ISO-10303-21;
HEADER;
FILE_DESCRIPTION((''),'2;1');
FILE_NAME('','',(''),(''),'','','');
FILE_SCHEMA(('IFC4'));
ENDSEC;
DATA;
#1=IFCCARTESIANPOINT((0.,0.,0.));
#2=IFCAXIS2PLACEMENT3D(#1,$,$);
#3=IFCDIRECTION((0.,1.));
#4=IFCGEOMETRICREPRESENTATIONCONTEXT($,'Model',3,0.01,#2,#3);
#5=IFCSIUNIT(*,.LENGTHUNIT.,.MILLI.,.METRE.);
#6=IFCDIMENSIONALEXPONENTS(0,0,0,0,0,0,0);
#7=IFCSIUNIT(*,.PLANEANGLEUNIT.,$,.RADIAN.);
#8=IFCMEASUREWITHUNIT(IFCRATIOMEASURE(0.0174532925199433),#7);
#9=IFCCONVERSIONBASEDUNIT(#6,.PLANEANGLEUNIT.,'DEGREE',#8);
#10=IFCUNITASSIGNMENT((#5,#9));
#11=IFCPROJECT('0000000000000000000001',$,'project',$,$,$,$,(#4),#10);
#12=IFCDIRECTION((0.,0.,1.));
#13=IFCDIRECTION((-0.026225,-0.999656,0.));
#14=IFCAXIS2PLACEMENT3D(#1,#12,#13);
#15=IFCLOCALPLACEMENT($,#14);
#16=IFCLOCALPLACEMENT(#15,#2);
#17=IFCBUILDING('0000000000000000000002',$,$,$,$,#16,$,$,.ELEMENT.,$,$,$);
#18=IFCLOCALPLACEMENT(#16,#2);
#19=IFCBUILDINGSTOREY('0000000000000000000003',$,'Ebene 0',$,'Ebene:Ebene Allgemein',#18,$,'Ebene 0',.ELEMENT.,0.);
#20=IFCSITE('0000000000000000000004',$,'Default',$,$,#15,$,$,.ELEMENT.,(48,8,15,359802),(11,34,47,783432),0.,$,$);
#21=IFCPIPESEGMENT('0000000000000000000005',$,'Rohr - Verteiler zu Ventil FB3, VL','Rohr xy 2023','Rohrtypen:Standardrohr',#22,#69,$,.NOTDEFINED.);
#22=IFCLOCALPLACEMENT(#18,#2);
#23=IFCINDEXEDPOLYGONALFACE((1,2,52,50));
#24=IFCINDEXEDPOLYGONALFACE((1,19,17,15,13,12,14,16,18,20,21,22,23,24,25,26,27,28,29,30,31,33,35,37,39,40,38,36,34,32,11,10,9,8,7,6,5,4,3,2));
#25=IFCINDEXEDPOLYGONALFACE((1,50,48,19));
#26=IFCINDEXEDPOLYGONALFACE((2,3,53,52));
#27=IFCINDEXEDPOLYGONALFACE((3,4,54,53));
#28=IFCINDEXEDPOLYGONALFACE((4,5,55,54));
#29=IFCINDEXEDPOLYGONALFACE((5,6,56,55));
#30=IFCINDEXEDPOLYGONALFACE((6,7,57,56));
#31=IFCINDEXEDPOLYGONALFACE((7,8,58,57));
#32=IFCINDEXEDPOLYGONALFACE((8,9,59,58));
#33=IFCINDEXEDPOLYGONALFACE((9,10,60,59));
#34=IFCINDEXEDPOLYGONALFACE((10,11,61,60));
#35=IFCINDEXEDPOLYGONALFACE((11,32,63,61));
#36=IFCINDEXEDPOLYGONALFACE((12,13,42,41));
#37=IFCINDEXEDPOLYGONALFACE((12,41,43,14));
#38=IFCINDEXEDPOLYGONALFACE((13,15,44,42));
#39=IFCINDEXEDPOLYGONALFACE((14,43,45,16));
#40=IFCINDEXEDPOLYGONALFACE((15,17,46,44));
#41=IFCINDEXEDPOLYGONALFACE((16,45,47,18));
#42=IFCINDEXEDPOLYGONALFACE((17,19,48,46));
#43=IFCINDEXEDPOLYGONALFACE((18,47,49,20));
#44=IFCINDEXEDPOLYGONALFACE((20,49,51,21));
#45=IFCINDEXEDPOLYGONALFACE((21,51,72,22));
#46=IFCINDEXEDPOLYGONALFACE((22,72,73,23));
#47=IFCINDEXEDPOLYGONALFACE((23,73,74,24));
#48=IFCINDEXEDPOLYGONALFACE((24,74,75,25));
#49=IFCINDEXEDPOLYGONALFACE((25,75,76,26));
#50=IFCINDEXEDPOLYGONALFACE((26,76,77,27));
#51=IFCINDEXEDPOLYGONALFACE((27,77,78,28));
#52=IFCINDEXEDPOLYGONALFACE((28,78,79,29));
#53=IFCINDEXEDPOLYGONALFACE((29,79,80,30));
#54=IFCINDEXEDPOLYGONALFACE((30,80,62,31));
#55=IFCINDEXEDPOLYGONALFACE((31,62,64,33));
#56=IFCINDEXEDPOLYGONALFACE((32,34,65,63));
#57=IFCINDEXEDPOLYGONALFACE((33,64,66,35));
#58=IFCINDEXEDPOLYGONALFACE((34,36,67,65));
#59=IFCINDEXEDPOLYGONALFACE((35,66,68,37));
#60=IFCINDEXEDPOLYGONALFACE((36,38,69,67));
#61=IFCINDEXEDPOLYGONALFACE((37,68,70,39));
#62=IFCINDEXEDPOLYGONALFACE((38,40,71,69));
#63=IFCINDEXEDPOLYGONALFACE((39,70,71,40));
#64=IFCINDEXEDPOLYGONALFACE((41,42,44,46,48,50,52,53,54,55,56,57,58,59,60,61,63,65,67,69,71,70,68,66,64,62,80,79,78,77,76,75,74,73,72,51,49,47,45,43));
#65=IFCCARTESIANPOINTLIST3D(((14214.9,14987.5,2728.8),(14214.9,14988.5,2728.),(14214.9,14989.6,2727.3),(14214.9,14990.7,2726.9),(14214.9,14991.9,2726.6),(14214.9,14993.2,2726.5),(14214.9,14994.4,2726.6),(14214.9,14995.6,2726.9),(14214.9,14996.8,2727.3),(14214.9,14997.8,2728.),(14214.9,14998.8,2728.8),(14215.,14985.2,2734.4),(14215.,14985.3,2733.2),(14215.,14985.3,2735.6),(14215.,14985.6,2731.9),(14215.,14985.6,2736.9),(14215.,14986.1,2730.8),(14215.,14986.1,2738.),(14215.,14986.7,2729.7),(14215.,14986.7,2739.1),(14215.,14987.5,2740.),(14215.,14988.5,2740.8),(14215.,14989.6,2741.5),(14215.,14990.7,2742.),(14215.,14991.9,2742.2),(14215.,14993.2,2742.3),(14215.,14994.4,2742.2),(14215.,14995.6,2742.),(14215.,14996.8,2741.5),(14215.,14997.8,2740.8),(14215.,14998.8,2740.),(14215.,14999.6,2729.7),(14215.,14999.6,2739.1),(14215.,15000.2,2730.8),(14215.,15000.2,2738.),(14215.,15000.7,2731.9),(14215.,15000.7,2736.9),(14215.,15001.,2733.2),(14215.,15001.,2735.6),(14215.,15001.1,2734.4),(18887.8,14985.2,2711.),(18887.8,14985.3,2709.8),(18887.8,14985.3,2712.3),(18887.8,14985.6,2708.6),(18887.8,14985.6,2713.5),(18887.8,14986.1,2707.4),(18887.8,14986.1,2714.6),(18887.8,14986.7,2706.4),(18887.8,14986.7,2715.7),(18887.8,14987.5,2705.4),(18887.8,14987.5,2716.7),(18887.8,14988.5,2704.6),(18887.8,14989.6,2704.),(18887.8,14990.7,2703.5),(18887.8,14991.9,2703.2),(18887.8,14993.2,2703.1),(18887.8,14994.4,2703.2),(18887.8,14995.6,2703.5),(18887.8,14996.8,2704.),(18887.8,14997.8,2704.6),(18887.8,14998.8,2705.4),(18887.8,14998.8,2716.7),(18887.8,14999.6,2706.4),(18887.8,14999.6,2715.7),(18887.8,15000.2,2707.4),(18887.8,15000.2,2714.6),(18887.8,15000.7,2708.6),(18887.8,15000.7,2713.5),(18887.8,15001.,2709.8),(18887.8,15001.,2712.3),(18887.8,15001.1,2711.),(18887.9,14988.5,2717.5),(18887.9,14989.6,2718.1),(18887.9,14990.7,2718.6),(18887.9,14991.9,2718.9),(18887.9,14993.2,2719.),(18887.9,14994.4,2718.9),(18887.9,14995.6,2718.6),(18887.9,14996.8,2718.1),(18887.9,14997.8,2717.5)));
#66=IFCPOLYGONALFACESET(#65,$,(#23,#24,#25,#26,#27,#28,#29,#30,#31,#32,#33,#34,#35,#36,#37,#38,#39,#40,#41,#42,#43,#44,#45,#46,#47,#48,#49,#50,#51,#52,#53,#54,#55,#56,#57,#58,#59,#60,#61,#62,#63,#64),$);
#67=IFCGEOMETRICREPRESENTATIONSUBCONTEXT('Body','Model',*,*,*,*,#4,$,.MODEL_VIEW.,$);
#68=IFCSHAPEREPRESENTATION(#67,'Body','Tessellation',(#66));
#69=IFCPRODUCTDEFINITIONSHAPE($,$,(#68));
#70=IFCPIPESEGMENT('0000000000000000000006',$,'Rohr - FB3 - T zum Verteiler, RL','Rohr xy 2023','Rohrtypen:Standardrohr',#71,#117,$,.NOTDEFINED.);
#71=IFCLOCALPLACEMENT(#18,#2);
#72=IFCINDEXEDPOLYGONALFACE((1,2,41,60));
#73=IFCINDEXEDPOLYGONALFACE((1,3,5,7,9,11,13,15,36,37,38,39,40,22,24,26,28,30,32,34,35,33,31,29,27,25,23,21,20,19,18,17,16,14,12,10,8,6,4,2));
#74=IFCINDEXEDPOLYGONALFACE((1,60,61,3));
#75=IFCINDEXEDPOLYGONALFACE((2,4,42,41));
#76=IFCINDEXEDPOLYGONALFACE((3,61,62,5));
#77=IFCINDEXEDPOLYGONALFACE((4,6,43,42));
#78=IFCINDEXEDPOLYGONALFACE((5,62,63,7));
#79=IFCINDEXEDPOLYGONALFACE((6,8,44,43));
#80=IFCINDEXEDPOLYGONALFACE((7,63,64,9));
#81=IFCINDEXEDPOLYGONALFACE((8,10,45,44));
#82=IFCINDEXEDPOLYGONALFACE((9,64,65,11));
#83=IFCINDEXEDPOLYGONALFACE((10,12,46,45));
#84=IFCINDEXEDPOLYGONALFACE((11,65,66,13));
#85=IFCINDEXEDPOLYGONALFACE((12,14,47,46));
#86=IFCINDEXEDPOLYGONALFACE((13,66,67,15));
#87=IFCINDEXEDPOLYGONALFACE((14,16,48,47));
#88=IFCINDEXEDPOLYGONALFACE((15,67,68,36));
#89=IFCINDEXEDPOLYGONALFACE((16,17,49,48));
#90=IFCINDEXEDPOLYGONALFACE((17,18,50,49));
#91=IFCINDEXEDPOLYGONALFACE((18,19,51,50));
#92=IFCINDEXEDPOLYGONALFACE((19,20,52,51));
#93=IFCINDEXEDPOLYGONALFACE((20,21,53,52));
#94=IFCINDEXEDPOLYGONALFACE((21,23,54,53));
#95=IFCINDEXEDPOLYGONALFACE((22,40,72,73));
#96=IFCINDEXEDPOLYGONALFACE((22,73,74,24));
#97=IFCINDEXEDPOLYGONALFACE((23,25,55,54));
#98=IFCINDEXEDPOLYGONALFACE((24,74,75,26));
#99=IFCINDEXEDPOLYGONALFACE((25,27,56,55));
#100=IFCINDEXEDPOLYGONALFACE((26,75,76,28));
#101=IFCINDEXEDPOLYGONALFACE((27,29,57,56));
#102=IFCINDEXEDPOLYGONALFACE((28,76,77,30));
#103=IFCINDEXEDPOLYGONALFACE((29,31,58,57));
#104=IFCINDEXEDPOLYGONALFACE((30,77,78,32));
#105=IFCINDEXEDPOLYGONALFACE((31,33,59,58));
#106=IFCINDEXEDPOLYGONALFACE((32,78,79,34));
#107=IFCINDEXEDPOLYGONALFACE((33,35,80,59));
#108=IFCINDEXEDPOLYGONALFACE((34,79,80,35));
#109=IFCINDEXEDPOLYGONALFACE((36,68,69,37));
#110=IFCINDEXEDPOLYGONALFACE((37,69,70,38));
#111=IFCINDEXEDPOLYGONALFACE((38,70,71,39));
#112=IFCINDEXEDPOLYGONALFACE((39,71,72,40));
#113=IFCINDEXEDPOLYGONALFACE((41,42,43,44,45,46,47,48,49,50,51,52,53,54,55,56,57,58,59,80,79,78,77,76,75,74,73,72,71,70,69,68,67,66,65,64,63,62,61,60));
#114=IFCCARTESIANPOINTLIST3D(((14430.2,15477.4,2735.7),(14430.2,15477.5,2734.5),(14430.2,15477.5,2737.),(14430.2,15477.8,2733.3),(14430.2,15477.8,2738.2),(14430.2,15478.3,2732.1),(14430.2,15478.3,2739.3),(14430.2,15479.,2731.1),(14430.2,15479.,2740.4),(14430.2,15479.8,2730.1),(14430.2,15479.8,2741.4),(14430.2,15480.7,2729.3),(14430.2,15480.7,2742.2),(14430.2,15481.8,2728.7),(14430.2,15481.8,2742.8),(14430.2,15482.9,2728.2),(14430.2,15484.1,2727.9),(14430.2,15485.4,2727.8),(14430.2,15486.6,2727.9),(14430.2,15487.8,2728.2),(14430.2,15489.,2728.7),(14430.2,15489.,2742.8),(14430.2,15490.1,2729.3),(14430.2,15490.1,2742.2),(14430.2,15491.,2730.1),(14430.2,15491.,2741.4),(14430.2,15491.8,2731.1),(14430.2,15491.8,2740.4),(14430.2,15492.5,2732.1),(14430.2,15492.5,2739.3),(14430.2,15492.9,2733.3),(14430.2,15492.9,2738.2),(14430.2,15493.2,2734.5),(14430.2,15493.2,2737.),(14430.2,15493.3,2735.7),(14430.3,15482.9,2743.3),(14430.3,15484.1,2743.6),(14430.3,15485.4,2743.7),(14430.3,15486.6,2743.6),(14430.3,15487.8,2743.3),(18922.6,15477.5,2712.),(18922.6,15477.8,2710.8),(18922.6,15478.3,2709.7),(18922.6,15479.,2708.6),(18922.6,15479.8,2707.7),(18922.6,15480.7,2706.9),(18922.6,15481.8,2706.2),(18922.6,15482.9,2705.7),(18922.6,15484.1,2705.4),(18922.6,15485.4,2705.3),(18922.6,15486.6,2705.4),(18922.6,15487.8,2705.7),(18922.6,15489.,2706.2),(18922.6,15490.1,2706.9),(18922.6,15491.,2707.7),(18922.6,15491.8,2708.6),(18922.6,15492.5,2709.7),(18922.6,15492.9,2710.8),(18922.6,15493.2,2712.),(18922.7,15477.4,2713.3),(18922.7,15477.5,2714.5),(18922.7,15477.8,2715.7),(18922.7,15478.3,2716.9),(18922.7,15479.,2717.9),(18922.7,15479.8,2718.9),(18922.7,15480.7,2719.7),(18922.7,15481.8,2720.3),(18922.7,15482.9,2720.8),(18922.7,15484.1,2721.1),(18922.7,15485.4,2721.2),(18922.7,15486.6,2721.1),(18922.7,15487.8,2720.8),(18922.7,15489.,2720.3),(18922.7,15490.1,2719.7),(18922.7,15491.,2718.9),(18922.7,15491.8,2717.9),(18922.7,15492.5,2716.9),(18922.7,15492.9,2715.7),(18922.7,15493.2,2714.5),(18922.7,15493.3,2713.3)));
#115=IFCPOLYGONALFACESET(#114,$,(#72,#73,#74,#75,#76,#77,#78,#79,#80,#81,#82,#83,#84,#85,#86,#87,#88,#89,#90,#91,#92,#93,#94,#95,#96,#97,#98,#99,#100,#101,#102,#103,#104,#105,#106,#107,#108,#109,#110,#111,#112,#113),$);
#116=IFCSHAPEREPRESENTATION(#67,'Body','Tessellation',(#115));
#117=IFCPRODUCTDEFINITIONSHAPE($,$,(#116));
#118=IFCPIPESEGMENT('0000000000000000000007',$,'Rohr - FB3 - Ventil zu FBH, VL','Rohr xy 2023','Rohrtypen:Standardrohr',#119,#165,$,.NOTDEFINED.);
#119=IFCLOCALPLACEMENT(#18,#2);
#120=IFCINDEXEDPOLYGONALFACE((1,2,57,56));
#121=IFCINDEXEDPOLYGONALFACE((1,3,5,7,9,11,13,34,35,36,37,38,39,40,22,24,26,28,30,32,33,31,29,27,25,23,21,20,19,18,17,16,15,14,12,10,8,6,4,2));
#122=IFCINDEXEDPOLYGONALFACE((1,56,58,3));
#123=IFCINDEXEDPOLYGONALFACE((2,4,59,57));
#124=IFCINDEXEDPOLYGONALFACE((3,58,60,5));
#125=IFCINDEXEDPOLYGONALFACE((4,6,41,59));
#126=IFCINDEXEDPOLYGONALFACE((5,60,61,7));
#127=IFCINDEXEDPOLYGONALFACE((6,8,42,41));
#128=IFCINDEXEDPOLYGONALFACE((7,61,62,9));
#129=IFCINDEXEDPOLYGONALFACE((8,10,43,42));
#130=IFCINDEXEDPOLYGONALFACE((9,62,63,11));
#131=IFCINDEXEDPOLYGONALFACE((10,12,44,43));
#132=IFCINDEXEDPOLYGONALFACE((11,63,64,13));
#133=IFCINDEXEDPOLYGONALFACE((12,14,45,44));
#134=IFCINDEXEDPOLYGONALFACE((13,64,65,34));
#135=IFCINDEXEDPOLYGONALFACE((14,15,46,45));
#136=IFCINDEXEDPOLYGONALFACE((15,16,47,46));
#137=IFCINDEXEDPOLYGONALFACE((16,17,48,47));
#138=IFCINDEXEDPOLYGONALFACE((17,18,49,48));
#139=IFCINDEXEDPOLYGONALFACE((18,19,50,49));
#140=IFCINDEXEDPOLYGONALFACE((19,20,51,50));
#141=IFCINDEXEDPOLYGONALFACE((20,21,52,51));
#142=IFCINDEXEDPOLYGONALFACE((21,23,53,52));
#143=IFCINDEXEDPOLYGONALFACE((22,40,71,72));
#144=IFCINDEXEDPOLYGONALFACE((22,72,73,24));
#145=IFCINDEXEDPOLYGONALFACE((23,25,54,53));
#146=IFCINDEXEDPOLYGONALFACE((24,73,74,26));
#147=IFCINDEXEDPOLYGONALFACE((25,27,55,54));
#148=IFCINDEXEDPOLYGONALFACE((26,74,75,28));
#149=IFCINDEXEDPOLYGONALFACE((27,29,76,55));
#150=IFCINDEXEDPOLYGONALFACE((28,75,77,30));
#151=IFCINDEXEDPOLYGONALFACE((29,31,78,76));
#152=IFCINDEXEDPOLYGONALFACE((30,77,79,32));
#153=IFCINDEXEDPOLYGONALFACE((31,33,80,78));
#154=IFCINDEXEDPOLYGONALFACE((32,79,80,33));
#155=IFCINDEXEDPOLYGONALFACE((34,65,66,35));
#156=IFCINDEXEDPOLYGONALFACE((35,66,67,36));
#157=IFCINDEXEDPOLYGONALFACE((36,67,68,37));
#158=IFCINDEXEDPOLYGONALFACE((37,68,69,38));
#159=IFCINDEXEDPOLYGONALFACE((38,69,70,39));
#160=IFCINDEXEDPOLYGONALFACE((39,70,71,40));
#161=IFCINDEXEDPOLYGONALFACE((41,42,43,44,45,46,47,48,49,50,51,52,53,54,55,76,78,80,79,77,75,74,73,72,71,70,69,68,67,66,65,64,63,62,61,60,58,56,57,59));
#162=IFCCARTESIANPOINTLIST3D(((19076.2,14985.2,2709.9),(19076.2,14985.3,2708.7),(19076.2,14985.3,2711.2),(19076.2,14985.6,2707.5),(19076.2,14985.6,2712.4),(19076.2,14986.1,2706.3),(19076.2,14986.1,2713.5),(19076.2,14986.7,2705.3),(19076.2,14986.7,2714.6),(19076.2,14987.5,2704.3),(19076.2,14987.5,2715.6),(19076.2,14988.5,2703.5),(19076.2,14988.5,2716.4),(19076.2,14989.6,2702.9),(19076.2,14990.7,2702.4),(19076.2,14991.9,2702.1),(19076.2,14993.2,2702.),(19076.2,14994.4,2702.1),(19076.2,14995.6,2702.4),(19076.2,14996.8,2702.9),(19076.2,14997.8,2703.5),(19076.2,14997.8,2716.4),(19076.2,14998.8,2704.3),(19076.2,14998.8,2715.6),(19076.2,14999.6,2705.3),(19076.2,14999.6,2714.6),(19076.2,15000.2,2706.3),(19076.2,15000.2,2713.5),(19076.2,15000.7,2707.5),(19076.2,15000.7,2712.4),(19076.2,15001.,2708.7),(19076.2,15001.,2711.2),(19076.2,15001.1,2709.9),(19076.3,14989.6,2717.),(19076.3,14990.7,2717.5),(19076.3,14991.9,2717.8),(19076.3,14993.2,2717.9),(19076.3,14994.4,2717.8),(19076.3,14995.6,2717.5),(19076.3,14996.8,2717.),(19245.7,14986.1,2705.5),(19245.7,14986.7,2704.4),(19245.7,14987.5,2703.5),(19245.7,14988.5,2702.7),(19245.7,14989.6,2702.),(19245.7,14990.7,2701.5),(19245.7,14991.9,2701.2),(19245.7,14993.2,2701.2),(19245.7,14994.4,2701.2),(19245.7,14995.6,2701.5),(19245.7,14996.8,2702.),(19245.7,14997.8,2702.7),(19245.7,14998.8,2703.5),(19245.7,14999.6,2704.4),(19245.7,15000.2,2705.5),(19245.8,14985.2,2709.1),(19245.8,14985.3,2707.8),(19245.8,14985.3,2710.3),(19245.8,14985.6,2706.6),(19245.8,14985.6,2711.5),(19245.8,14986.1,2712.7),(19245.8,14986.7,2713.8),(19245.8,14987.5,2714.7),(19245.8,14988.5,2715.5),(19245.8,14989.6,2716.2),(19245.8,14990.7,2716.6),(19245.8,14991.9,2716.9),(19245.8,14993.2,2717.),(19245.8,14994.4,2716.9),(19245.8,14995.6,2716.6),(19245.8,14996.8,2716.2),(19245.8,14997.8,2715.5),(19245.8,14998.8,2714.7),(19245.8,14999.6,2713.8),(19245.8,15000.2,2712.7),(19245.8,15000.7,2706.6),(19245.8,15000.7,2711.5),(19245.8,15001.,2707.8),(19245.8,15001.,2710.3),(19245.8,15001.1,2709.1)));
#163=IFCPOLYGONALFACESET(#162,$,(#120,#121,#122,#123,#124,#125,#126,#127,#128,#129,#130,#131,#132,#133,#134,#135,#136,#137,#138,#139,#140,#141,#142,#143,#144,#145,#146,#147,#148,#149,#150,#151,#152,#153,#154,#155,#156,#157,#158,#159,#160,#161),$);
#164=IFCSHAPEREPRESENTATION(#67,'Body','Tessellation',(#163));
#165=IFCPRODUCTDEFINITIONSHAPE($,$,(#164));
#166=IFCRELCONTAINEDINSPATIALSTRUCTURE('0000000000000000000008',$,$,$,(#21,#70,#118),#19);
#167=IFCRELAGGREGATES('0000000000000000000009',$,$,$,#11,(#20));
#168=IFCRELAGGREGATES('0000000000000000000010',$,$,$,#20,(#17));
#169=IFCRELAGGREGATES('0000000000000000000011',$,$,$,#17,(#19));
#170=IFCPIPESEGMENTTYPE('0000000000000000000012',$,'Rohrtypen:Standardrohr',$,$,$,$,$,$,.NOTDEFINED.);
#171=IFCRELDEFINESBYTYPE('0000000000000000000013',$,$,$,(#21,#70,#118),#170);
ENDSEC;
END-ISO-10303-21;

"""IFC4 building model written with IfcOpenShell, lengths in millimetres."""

from ifc_helpers import new_model, entity, si_unit, converted_unit, direction, frame, origin, place, context, subcontext, project, spatial, indexed_curve, outline, extrude, type_object, element, save


model = new_model("IFC4")

# Units and contexts
model_context = context("Model", 3, precision=0.01, world=origin(), true_north=direction((0.0, 1.0)))
body_context = subcontext(model_context, "Body", "Model", "MODEL_VIEW")
ifc_project = project(units=[si_unit("LENGTHUNIT", "METRE", prefix="MILLI"), converted_unit("PLANEANGLEUNIT", "DEGREE", entity("IfcRatioMeasure", 0.0174532925199433), si_unit("PLANEANGLEUNIT", "RADIAN"), dimensions=[0, 0, 0, 0, 0, 0, 0])], contexts=[model_context])

# Site, building, storey
site_placement = place(None, frame((0.0, 0.0, 0.0), z_axis=(0.0, 0.0, 1.0), x_axis=(-0.026225, -0.999656, 0.0)))
site = spatial("IfcSite", under=ifc_project, at=site_placement, Name="Default", CompositionType="ELEMENT", RefLatitude=(48, 8, 15, 359802), RefLongitude=(11, 34, 47, 783432), RefElevation=0.0)
building_placement = place(site_placement, origin())
building = spatial("IfcBuilding", under=site, at=building_placement, CompositionType="ELEMENT")
storey_placement = place(building_placement, origin())
storey = spatial("IfcBuildingStorey", under=building, at=storey_placement, Name="Ebene 0", ObjectType="Ebene:Ebene Allgemein", LongName="Ebene 0", CompositionType="ELEMENT", Elevation=0.0)

# Pipe segments
pipe_segment_type = type_object("IfcPipeSegmentType", Name="Rohrtypen:Standardrohr", PredefinedType="NOTDEFINED")
pipe_segment_1_placement = place(storey_placement, origin())
element("IfcPipeSegment", 1, at=pipe_segment_1_placement, inside=storey, type_object=pipe_segment_type, Name="Rohr - Verteiler zu Ventil FB3, VL", Description="Rohr xy 2023", ObjectType="Rohrtypen:Standardrohr", PredefinedType="NOTDEFINED", context=body_context, shape_type="SweptSolid", body=[
    extrude(outline(indexed_curve([(7.9, 0.0), (7.8, 1.2), (7.6, 2.5), (7.1, 3.6), (6.4, 4.7), (5.6, 5.6), (4.7, 6.4), (3.6, 7.1), (2.5, 7.6), (1.2, 7.8), (0.0, 7.9), (-1.2, 7.8), (-2.5, 7.6), (-3.6, 7.1), (-4.7, 6.4), (-5.6, 5.6), (-6.4, 4.7), (-7.1, 3.6), (-7.6, 2.5), (-7.8, 1.2), (-7.9, 0.0), (-7.8, -1.2), (-7.6, -2.5), (-7.1, -3.6), (-6.4, -4.7), (-5.6, -5.6), (-4.7, -6.4), (-3.6, -7.1), (-2.5, -7.6), (-1.2, -7.8), (0.0, -7.9), (1.2, -7.8), (2.5, -7.6), (3.6, -7.1), (4.7, -6.4), (5.6, -5.6), (6.4, -4.7), (7.1, -3.6), (7.6, -2.5), (7.8, -1.2), (7.9, 0.0)], self_intersect=False)), frame((18887.8, 14993.2, 2711.0), z_axis=(-0.999988, 0.0, 0.005), x_axis=(0.0, 1.0, 0.0)), (0.0, 0.0, 1.0), 4672.9),
])
pipe_segment_2_placement = place(storey_placement, origin())
element("IfcPipeSegment", 2, at=pipe_segment_2_placement, inside=storey, type_object=pipe_segment_type, Name="Rohr - FB3 - T zum Verteiler, RL", Description="Rohr xy 2023", ObjectType="Rohrtypen:Standardrohr", PredefinedType="NOTDEFINED", context=body_context, shape_type="SweptSolid", body=[
    extrude(outline(indexed_curve([(7.9, 0.0), (7.8, 1.2), (7.6, 2.5), (7.1, 3.6), (6.4, 4.7), (5.6, 5.6), (4.7, 6.4), (3.6, 7.1), (2.5, 7.6), (1.2, 7.8), (0.0, 7.9), (-1.2, 7.8), (-2.5, 7.6), (-3.6, 7.1), (-4.7, 6.4), (-5.6, 5.6), (-6.4, 4.7), (-7.1, 3.6), (-7.6, 2.5), (-7.8, 1.2), (-7.9, 0.0), (-7.8, -1.2), (-7.6, -2.5), (-7.1, -3.6), (-6.4, -4.7), (-5.6, -5.6), (-4.7, -6.4), (-3.6, -7.1), (-2.5, -7.6), (-1.2, -7.8), (0.0, -7.9), (1.2, -7.8), (2.5, -7.6), (3.6, -7.1), (4.7, -6.4), (5.6, -5.6), (6.4, -4.7), (7.1, -3.6), (7.6, -2.5), (7.8, -1.2), (7.9, 0.0)], self_intersect=False)), frame((14430.2, 15485.4, 2735.7), z_axis=(0.999988, 0.0, -0.005), x_axis=(0.0, 1.0, 0.0)), (0.0, 0.0, 1.0), 4492.5),
])
pipe_segment_3_placement = place(storey_placement, origin())
element("IfcPipeSegment", 3, at=pipe_segment_3_placement, inside=storey, type_object=pipe_segment_type, Name="Rohr - FB3 - Ventil zu FBH, VL", Description="Rohr xy 2023", ObjectType="Rohrtypen:Standardrohr", PredefinedType="NOTDEFINED", context=body_context, shape_type="SweptSolid", body=[
    extrude(outline(indexed_curve([(7.9, 0.0), (7.8, 1.2), (7.6, 2.5), (7.1, 3.6), (6.4, 4.7), (5.6, 5.6), (4.7, 6.4), (3.6, 7.1), (2.5, 7.6), (1.2, 7.8), (0.0, 7.9), (-1.2, 7.8), (-2.5, 7.6), (-3.6, 7.1), (-4.7, 6.4), (-5.6, 5.6), (-6.4, 4.7), (-7.1, 3.6), (-7.6, 2.5), (-7.8, 1.2), (-7.9, 0.0), (-7.8, -1.2), (-7.6, -2.5), (-7.1, -3.6), (-6.4, -4.7), (-5.6, -5.6), (-4.7, -6.4), (-3.6, -7.1), (-2.5, -7.6), (-1.2, -7.8), (0.0, -7.9), (1.2, -7.8), (2.5, -7.6), (3.6, -7.1), (4.7, -6.4), (5.6, -5.6), (6.4, -4.7), (7.1, -3.6), (7.6, -2.5), (7.8, -1.2), (7.9, 0.0)], self_intersect=False)), frame((19076.2, 14993.2, 2709.9), z_axis=(0.999988, 0.0, -0.005), x_axis=(0.0, 1.0, 0.0)), (0.0, 0.0, 1.0), 169.5),
])

save(model, "model.ifc")
